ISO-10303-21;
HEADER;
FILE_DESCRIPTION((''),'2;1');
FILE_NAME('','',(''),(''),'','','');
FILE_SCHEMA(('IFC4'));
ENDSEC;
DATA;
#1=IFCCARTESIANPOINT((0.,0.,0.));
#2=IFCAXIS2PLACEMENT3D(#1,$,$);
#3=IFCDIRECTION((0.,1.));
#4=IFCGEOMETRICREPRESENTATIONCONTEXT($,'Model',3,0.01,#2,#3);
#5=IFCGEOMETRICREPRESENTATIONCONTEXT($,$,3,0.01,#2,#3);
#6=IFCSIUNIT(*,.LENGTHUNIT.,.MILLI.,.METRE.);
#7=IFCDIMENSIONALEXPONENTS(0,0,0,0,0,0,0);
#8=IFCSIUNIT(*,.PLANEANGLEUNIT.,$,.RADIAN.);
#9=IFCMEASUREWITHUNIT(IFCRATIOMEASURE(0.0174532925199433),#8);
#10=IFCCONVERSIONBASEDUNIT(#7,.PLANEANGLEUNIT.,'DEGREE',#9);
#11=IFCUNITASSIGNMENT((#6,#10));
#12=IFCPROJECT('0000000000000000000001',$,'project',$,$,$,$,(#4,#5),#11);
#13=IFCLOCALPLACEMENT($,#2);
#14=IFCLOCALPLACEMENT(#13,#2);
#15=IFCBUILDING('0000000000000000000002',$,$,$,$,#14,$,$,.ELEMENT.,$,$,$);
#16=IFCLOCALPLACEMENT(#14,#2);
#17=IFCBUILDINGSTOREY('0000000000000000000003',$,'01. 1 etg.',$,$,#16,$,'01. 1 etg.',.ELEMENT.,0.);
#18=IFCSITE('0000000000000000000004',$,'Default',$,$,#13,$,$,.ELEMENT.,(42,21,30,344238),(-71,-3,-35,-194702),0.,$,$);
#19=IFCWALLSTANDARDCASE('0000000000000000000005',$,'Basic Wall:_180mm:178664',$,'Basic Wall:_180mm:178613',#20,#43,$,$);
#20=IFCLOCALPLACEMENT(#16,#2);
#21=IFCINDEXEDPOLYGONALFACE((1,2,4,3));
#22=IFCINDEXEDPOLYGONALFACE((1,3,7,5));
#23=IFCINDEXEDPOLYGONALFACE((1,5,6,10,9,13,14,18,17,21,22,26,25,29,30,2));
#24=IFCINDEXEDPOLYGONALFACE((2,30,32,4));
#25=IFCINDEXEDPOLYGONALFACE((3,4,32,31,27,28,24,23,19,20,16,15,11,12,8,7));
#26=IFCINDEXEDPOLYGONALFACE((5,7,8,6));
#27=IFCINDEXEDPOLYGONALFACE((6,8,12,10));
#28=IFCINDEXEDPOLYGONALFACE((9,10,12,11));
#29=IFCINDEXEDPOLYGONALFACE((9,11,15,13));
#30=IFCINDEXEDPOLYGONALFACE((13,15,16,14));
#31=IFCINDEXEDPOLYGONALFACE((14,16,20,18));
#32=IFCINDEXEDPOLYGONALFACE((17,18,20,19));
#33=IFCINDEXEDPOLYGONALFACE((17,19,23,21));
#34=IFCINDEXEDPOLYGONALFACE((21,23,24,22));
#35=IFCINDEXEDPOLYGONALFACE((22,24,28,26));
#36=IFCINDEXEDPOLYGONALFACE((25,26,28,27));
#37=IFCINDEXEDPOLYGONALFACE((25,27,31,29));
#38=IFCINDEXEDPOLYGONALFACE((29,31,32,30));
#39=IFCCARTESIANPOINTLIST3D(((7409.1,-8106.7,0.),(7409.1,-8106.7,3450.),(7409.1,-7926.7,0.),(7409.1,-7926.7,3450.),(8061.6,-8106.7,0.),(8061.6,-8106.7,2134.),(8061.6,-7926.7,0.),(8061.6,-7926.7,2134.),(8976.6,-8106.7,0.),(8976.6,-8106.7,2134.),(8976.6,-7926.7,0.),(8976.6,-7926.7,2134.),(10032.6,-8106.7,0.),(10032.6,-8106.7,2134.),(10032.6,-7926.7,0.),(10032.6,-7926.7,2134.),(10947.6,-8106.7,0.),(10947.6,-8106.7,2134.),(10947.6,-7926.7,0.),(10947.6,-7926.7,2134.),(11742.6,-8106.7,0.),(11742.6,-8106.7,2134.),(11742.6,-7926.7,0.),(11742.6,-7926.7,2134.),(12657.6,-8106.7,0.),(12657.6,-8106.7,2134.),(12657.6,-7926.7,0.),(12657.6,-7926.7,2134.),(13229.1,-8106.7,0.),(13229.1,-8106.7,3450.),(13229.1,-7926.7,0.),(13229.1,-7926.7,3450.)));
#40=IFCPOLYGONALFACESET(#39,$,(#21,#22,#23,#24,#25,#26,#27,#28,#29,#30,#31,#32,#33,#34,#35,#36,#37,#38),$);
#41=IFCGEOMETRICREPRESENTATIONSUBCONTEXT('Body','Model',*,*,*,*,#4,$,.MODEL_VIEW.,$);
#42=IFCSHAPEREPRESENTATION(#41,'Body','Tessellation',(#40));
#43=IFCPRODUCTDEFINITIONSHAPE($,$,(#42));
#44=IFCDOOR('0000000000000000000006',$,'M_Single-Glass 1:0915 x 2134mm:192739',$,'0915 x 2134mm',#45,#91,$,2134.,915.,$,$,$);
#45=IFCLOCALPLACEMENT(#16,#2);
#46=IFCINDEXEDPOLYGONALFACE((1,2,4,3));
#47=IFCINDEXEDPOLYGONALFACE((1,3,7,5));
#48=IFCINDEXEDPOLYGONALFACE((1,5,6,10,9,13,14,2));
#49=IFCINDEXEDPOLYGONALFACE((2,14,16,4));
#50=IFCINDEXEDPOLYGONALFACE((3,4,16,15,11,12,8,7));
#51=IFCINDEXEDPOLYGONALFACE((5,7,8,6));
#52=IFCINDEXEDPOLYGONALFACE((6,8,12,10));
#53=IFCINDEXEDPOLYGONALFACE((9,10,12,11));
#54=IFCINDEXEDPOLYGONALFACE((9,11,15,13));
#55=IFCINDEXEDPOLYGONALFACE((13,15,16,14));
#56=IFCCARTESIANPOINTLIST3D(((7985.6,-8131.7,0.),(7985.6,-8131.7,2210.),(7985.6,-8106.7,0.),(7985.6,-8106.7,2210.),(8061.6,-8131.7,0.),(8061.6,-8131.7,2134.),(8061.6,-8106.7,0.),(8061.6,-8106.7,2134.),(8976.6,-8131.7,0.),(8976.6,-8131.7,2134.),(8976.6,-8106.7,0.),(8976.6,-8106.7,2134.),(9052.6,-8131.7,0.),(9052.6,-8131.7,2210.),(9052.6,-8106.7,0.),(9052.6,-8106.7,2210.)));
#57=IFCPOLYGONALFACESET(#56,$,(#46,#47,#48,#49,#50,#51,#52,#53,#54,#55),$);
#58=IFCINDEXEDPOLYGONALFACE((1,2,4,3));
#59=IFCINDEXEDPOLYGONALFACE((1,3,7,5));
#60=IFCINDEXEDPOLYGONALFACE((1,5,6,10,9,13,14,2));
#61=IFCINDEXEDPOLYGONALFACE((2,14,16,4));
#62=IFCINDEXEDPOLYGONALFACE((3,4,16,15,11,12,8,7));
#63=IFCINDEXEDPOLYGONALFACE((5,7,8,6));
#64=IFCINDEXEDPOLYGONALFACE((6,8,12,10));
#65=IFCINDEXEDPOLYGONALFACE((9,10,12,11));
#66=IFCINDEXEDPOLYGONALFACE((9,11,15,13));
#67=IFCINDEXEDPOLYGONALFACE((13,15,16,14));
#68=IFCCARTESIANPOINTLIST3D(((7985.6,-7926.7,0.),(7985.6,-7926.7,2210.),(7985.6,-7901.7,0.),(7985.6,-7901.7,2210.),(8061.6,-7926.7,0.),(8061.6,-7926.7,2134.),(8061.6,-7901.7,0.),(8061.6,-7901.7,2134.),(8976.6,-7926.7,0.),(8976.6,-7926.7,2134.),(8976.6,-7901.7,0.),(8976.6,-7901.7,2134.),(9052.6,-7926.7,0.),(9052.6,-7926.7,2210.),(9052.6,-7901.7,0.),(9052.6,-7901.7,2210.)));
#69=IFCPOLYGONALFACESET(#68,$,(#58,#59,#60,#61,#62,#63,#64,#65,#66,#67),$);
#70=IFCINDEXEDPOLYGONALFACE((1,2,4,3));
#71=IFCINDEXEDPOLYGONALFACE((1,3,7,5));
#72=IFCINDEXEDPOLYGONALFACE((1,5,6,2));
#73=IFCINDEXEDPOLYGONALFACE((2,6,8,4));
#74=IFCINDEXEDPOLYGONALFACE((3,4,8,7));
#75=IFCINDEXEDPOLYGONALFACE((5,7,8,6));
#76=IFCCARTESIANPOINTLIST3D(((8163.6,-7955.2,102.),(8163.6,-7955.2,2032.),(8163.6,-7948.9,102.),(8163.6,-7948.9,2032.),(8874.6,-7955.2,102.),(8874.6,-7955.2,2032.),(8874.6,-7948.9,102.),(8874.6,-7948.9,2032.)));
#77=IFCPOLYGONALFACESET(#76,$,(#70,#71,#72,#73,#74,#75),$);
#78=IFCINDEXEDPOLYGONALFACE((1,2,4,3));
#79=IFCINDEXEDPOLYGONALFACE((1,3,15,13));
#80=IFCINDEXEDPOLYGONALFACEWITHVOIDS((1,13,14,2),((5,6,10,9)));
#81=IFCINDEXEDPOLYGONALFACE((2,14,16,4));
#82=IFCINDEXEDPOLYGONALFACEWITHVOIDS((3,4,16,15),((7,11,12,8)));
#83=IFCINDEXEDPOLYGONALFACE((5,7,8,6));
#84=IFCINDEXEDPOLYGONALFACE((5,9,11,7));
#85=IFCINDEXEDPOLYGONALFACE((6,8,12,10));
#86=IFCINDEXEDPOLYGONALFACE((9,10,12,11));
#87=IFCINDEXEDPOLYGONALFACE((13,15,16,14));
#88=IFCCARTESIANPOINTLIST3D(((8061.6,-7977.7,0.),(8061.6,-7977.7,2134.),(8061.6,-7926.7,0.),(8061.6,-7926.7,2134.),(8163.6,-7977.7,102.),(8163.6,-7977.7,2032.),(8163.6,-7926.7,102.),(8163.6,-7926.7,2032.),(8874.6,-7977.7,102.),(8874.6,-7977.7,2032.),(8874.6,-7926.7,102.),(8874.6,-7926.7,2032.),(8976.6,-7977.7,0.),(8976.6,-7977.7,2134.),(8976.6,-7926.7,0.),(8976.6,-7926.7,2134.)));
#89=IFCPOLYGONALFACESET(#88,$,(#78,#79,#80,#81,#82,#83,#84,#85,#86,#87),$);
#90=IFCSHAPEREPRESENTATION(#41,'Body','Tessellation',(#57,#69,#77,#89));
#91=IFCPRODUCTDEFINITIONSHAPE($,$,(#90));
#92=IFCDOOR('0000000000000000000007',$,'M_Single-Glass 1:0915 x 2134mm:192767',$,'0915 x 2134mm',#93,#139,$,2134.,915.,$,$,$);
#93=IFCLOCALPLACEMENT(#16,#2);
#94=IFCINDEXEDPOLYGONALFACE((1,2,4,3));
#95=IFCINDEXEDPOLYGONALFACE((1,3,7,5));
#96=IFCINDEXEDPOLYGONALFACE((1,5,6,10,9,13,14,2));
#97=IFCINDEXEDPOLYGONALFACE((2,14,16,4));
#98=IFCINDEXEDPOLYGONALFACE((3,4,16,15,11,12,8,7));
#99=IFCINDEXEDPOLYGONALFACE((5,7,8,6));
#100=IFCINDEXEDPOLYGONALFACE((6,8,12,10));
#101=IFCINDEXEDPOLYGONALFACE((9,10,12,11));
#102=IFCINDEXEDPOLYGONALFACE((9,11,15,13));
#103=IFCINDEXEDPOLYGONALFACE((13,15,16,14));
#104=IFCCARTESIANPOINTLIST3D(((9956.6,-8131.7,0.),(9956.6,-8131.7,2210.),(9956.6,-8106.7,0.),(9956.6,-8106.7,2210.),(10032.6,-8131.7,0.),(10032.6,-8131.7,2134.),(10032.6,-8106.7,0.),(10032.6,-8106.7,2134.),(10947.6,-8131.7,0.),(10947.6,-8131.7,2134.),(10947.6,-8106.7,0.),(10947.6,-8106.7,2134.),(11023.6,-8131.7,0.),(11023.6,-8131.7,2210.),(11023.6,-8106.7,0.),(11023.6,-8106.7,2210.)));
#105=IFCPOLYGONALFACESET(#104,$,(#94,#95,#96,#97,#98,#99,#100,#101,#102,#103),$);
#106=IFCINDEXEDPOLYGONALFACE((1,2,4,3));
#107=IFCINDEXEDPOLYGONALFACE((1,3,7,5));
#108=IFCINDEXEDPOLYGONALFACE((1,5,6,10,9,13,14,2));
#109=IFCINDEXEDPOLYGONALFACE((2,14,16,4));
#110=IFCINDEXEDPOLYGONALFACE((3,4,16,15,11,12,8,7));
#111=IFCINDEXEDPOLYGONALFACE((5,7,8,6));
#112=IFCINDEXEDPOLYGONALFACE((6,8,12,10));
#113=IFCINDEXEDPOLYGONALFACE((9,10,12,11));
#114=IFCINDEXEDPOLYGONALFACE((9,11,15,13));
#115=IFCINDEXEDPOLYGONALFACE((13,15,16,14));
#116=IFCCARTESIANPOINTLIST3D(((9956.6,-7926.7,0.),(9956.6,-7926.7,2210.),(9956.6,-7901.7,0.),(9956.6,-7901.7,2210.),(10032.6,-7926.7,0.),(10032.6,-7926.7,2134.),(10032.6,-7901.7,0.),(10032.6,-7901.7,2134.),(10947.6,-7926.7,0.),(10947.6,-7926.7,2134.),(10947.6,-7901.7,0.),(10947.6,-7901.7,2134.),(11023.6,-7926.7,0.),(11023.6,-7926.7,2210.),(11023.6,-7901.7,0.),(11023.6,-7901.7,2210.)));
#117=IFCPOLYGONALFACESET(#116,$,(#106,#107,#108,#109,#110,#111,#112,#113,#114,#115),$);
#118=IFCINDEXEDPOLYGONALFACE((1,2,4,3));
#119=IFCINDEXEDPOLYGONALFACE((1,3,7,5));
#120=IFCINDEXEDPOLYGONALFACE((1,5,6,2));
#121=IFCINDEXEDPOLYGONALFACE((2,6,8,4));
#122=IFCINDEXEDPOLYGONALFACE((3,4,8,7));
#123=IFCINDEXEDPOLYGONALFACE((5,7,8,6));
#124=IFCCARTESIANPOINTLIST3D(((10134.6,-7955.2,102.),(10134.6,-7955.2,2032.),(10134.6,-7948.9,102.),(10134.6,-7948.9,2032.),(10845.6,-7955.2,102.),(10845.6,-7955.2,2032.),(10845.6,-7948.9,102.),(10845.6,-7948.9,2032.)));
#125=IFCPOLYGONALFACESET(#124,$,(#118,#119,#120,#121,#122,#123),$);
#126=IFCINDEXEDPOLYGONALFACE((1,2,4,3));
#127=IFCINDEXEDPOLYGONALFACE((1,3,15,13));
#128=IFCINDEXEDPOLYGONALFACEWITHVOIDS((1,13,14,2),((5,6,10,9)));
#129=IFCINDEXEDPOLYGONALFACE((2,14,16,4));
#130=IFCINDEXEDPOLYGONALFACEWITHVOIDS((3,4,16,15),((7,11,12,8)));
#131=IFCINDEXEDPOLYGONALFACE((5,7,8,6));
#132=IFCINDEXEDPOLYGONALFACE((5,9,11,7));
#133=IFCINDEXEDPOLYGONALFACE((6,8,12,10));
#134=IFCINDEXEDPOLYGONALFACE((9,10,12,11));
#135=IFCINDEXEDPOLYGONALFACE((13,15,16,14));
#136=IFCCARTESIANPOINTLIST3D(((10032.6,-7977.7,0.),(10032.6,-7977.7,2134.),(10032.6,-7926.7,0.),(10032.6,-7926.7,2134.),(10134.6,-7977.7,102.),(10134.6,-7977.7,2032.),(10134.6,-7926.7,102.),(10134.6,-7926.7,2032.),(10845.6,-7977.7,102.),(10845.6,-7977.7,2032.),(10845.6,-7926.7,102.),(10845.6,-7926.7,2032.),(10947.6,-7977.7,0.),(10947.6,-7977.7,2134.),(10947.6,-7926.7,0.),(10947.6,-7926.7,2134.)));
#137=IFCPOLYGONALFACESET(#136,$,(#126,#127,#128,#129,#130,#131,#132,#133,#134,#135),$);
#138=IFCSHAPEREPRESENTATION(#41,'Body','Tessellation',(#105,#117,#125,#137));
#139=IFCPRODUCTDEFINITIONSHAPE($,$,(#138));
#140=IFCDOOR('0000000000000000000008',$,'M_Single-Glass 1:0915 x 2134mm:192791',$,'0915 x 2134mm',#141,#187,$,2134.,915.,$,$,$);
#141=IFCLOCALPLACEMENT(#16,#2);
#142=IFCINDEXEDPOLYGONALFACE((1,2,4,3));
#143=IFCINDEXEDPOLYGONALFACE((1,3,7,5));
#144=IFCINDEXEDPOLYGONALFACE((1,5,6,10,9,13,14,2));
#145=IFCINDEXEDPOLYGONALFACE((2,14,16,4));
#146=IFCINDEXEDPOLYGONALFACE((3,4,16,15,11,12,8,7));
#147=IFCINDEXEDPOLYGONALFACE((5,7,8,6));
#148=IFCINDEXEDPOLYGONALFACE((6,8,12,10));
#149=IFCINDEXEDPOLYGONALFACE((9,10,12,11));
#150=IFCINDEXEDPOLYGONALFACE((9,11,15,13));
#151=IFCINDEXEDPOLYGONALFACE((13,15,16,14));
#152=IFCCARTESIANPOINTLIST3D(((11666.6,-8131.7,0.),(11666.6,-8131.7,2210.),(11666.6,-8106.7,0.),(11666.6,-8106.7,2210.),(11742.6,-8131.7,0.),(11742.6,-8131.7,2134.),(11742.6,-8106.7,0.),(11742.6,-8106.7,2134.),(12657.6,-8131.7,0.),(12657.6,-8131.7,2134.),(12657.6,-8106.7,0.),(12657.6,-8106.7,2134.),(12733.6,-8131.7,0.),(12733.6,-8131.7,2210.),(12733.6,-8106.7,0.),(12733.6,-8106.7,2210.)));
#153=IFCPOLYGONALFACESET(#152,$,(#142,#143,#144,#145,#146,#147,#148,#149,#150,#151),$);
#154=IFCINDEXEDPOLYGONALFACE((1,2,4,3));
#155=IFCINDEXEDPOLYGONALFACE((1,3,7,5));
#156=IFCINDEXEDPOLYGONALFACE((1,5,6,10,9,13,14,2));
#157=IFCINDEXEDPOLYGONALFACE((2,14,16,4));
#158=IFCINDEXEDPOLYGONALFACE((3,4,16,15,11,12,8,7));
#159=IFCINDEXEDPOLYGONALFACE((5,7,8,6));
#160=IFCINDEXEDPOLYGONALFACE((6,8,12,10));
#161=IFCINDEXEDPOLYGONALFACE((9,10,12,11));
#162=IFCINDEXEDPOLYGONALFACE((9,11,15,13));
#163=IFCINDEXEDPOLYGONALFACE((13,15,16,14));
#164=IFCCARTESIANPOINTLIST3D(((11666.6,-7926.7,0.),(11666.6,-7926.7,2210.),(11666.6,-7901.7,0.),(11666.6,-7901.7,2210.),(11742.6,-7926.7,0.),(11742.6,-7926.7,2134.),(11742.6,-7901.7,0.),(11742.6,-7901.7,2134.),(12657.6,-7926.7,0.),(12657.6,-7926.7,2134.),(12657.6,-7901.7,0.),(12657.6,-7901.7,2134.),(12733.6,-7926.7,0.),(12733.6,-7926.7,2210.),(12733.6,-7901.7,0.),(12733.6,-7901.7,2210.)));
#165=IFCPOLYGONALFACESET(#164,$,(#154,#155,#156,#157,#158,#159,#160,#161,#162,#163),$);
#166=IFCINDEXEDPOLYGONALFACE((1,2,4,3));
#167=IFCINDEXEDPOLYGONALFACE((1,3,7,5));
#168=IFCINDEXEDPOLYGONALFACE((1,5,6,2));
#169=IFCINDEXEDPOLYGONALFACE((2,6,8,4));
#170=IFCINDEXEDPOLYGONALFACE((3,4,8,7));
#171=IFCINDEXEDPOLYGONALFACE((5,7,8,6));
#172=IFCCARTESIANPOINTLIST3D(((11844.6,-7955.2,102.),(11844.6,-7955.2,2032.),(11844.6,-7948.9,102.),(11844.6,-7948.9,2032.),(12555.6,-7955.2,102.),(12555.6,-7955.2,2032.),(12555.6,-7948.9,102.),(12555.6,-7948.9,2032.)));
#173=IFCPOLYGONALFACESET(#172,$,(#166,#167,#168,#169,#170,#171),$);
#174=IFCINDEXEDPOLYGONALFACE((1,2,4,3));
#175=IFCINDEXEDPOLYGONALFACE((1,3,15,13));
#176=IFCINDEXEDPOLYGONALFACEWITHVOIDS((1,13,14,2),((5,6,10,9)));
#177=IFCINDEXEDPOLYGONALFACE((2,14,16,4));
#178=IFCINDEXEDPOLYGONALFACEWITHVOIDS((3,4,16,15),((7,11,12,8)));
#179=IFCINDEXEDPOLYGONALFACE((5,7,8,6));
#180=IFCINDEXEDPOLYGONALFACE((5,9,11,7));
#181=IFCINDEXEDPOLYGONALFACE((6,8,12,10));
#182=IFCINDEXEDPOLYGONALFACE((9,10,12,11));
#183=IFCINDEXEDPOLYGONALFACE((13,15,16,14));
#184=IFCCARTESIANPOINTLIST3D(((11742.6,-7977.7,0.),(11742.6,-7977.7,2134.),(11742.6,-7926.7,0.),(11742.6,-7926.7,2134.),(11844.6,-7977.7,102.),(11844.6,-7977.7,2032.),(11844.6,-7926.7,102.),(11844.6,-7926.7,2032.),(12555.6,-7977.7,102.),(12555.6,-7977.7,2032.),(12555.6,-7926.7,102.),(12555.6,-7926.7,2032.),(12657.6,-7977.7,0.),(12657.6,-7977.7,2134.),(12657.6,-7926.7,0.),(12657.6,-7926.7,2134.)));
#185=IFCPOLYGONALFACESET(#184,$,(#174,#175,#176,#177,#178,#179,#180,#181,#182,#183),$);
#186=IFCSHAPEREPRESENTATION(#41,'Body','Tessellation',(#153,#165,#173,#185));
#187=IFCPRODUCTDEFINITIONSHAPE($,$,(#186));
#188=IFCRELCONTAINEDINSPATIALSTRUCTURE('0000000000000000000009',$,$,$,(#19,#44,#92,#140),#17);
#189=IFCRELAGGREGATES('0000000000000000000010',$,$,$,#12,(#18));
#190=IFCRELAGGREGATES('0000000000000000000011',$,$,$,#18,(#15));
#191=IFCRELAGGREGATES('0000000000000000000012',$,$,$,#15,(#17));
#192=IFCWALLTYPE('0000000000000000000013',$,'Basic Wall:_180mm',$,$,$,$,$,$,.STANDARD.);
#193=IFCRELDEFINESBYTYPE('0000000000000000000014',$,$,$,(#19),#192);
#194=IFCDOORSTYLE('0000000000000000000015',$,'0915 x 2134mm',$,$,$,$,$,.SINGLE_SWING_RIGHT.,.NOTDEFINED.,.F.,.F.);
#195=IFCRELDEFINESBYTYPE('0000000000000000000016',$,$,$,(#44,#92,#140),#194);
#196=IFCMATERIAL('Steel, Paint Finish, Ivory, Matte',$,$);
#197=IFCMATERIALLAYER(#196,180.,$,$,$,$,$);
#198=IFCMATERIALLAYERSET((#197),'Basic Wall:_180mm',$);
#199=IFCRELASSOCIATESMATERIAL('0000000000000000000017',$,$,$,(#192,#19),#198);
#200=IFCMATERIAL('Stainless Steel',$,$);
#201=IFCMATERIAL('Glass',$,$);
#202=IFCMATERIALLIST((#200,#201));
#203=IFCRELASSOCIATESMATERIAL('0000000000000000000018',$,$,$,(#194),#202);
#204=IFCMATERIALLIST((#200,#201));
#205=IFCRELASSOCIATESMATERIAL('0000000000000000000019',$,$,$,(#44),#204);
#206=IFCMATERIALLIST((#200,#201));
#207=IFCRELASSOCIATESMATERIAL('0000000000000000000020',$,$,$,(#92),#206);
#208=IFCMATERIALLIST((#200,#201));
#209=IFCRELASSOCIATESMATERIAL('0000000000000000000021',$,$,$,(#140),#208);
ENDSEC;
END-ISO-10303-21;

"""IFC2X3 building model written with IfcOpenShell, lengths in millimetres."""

from ifc_helpers import new_model, entity, si_unit, converted_unit, direction, frame, frame_2d, origin, place, context, subcontext, project, spatial, polyline, rectangle, outline, extrude, clip, bounded_halfspace, source, transform, mapped, material, material_list, layer, layer_set, layer_usage, type_object, type_shapes, element, fill, save


model = new_model("IFC2X3")

# Units and contexts
model_context = context("Model", 3, precision=0.01, world=origin(), true_north=direction((0.0, 1.0)))
context_of_model = context(None, 3, precision=0.01, world=origin(), true_north=direction((0.0, 1.0)))
body_context = subcontext(model_context, "Body", "Model", "MODEL_VIEW")
ifc_project = project(units=[si_unit("LENGTHUNIT", "METRE", prefix="MILLI"), converted_unit("PLANEANGLEUNIT", "DEGREE", entity("IfcRatioMeasure", 0.0174532925199433), si_unit("PLANEANGLEUNIT", "RADIAN"), dimensions=[0, 0, 0, 0, 0, 0, 0])], contexts=[model_context, context_of_model])

# Site, building, storey
site_placement = place(None, origin())
site = spatial("IfcSite", under=ifc_project, at=site_placement, Name="Default", CompositionType="ELEMENT", RefLatitude=(42, 21, 30, 344238), RefLongitude=(-71, -3, -35, -194702), RefElevation=0.0)
building_placement = place(site_placement, origin())
building = spatial("IfcBuilding", under=site, at=building_placement, CompositionType="ELEMENT")
storey_placement = place(building_placement, origin())
storey = spatial("IfcBuildingStorey", under=building, at=storey_placement, Name="01. 1 etg.", LongName="01. 1 etg.", CompositionType="ELEMENT", Elevation=0.0)

# Shared definitions
ifc_material_1 = material(Name="Glass")

# Shared definitions
ifc_material_2 = material(Name="Stainless Steel")
ifc_material_3 = material(Name="Steel, Paint Finish, Ivory, Matte")

# Wall, openings, doors
ifc_layer_1 = layer(ifc_material_3, 180.0)
ifc_layer_set_1 = layer_set([ifc_layer_1], Name="Basic Wall:_180mm")
ifc_layer_usage_1 = layer_usage(ifc_layer_set_1, "AXIS2", "NEGATIVE", 90.0)
wall_type_1 = type_object("IfcWallType", Name="Basic Wall:_180mm", PredefinedType="STANDARD", material=ifc_layer_set_1)
wall_1_placement = place(storey_placement, frame((13229.1, -8016.7, 0.0), z_axis=(0.0, 0.0, 1.0), x_axis=(-1.0, 0.0, 0.0)))
wall_1 = element("IfcWallStandardCase", 1, at=wall_1_placement, inside=storey, type_object=wall_type_1, material=ifc_layer_usage_1, Name="Basic Wall:_180mm:178664", ObjectType="Basic Wall:_180mm:178613", context=body_context, shape_type="Clipping", body=[
    clip(extrude(rectangle(XDim=5820.0, YDim=180.0, at=frame_2d((2910.0, 0.0), x_axis=(-1.0, 0.0))), origin(), (0.0, 0.0, 1.0), 3450.0), bounded_halfspace(frame((0.0, -90.0, 3450.0), z_axis=(0.0, 0.0, -1.0), x_axis=(0.0, 1.0, 0.0)), True, frame((0.0, -90.0, 3450.0)), polyline([(0.0, 0.0), (180.0, 0.0), (1878.0, 0.0), (1978.0, 0.0), (3500.0, 0.0), (3600.0, 0.0), (5820.0, 0.0), (5820.0, 180.0), (0.0, 180.0), (0.0, 0.0)]))),
])
opening_1_placement = place(wall_1_placement, frame((5167.5, 90.0, 0.0)))
opening_1 = element("IfcOpeningElement", 2, at=opening_1_placement, cuts=wall_1, ObjectType="Opening", context=body_context, shape_type="SweptSolid", body=[
    extrude(rectangle(XDim=915.0, YDim=2134.0, at=frame_2d((1067.0, 457.5), x_axis=(0.0, 1.0))), frame((0.0, 0.0, 0.0), z_axis=(0.0, -1.0, 0.0), x_axis=(0.0, 0.0, 1.0)), (0.0, 0.0, 1.0), 180.0),
])
opening_2_placement = place(wall_1_placement, frame((3196.5, 90.0, 0.0)))
opening_2 = element("IfcOpeningElement", 3, at=opening_2_placement, cuts=wall_1, ObjectType="Opening", context=body_context, shape_type="SweptSolid", body=[
    extrude(rectangle(XDim=915.0, YDim=2134.0, at=frame_2d((1067.0, 457.5), x_axis=(0.0, 1.0))), frame((0.0, 0.0, 0.0), z_axis=(0.0, -1.0, 0.0), x_axis=(0.0, 0.0, 1.0)), (0.0, 0.0, 1.0), 180.0),
])
opening_3_placement = place(wall_1_placement, frame((1486.5, 90.0, 0.0)))
opening_3 = element("IfcOpeningElement", 4, at=opening_3_placement, cuts=wall_1, ObjectType="Opening", context=body_context, shape_type="SweptSolid", body=[
    extrude(rectangle(XDim=915.0, YDim=2134.0, at=frame_2d((1067.0, 457.5), x_axis=(0.0, 1.0))), frame((0.0, 0.0, 0.0), z_axis=(0.0, -1.0, 0.0), x_axis=(0.0, 0.0, 1.0)), (0.0, 0.0, 1.0), 180.0),
])
ifc_material_list_1 = material_list([ifc_material_2, ifc_material_1])
ifc_material_list_2 = material_list([ifc_material_2, ifc_material_1])
door_style_1 = type_object("IfcDoorStyle", Name="0915 x 2134mm", ConstructionType="NOTDEFINED", OperationType="SINGLE_SWING_RIGHT", ParameterTakesPrecedence=False, Sizeable=False, material=ifc_material_list_2)
shared_shape_1 = source(origin(), body_context, "Body", "SweptSolid", [
    extrude(outline(polyline([(-457.5, -1048.0), (-457.5, 1086.0), (-533.5, 1086.0), (-533.5, -1124.0), (533.5, -1124.0), (533.5, 1086.0), (457.5, 1086.0), (457.5, -1048.0), (-457.5, -1048.0)])), frame((457.5, -25.0, 1086.0), z_axis=(0.0, -1.0, 0.0), x_axis=(-1.0, 0.0, 0.0)), (0.0, 0.0, -1.0), 25.0),
    extrude(outline(polyline([(-457.5, -1048.0), (-457.5, 1086.0), (-533.5, 1086.0), (-533.5, -1124.0), (533.5, -1124.0), (533.5, 1086.0), (457.5, 1086.0), (457.5, -1048.0), (-457.5, -1048.0)])), frame((457.5, 180.0, 1086.0), z_axis=(0.0, -1.0, 0.0), x_axis=(-1.0, 0.0, 0.0)), (0.0, 0.0, -1.0), 25.0),
    extrude(rectangle(XDim=6.3, YDim=711.0, at=frame_2d((0.0, 0.0), x_axis=(1.0, 0.0))), frame((457.5, 154.6, 102.0), z_axis=(0.0, 0.0, 1.0), x_axis=(0.0, 1.0, 0.0)), (0.0, 0.0, 1.0), 1930.0),
    extrude(outline(polyline([(-1067.0, -457.5), (1067.0, -457.5), (1067.0, 457.5), (-1067.0, 457.5), (-1067.0, -457.5)]), holes=[polyline([(-965.0, 355.5), (965.0, 355.5), (965.0, -355.5), (-965.0, -355.5), (-965.0, 355.5)])]), frame((457.5, 129.0, 1067.0), z_axis=(0.0, 1.0, 0.0), x_axis=(0.0, 0.0, -1.0)), (0.0, 0.0, 1.0), 51.0),
])
type_shapes(door_style_1, [shared_shape_1])
door_1_placement = place(opening_1_placement, frame((0.0, 0.0, 0.0), z_axis=(0.0, 0.0, 1.0), x_axis=(-1.0, 0.0, 0.0)))
door_1 = element("IfcDoor", 5, at=door_1_placement, inside=storey, type_object=door_style_1, material=ifc_material_list_1, Name="M_Single-Glass 1:0915 x 2134mm:192739", ObjectType="0915 x 2134mm", OverallHeight=2134.0, OverallWidth=915.0, context=body_context, shape_type="MappedRepresentation", body=[
    mapped(shared_shape_1, transform((0.0, 0.0, 0.0), scale=1.0)),
])
fill(opening_1, door_1)
ifc_material_list_3 = material_list([ifc_material_2, ifc_material_1])
door_2_placement = place(opening_2_placement, frame((0.0, 0.0, 0.0), z_axis=(0.0, 0.0, 1.0), x_axis=(-1.0, 0.0, 0.0)))
door_2 = element("IfcDoor", 6, at=door_2_placement, inside=storey, type_object=door_style_1, material=ifc_material_list_3, Name="M_Single-Glass 1:0915 x 2134mm:192767", ObjectType="0915 x 2134mm", OverallHeight=2134.0, OverallWidth=915.0, context=body_context, shape_type="MappedRepresentation", body=[
    mapped(shared_shape_1, transform((0.0, 0.0, 0.0), scale=1.0)),
])
fill(opening_2, door_2)
ifc_material_list_4 = material_list([ifc_material_2, ifc_material_1])
door_3_placement = place(opening_3_placement, frame((0.0, 0.0, 0.0), z_axis=(0.0, 0.0, 1.0), x_axis=(-1.0, 0.0, 0.0)))
door_3 = element("IfcDoor", 7, at=door_3_placement, inside=storey, type_object=door_style_1, material=ifc_material_list_4, Name="M_Single-Glass 1:0915 x 2134mm:192791", ObjectType="0915 x 2134mm", OverallHeight=2134.0, OverallWidth=915.0, context=body_context, shape_type="MappedRepresentation", body=[
    mapped(shared_shape_1, transform((0.0, 0.0, 0.0), scale=1.0)),
])
fill(opening_3, door_3)

save(model, "model.ifc")
